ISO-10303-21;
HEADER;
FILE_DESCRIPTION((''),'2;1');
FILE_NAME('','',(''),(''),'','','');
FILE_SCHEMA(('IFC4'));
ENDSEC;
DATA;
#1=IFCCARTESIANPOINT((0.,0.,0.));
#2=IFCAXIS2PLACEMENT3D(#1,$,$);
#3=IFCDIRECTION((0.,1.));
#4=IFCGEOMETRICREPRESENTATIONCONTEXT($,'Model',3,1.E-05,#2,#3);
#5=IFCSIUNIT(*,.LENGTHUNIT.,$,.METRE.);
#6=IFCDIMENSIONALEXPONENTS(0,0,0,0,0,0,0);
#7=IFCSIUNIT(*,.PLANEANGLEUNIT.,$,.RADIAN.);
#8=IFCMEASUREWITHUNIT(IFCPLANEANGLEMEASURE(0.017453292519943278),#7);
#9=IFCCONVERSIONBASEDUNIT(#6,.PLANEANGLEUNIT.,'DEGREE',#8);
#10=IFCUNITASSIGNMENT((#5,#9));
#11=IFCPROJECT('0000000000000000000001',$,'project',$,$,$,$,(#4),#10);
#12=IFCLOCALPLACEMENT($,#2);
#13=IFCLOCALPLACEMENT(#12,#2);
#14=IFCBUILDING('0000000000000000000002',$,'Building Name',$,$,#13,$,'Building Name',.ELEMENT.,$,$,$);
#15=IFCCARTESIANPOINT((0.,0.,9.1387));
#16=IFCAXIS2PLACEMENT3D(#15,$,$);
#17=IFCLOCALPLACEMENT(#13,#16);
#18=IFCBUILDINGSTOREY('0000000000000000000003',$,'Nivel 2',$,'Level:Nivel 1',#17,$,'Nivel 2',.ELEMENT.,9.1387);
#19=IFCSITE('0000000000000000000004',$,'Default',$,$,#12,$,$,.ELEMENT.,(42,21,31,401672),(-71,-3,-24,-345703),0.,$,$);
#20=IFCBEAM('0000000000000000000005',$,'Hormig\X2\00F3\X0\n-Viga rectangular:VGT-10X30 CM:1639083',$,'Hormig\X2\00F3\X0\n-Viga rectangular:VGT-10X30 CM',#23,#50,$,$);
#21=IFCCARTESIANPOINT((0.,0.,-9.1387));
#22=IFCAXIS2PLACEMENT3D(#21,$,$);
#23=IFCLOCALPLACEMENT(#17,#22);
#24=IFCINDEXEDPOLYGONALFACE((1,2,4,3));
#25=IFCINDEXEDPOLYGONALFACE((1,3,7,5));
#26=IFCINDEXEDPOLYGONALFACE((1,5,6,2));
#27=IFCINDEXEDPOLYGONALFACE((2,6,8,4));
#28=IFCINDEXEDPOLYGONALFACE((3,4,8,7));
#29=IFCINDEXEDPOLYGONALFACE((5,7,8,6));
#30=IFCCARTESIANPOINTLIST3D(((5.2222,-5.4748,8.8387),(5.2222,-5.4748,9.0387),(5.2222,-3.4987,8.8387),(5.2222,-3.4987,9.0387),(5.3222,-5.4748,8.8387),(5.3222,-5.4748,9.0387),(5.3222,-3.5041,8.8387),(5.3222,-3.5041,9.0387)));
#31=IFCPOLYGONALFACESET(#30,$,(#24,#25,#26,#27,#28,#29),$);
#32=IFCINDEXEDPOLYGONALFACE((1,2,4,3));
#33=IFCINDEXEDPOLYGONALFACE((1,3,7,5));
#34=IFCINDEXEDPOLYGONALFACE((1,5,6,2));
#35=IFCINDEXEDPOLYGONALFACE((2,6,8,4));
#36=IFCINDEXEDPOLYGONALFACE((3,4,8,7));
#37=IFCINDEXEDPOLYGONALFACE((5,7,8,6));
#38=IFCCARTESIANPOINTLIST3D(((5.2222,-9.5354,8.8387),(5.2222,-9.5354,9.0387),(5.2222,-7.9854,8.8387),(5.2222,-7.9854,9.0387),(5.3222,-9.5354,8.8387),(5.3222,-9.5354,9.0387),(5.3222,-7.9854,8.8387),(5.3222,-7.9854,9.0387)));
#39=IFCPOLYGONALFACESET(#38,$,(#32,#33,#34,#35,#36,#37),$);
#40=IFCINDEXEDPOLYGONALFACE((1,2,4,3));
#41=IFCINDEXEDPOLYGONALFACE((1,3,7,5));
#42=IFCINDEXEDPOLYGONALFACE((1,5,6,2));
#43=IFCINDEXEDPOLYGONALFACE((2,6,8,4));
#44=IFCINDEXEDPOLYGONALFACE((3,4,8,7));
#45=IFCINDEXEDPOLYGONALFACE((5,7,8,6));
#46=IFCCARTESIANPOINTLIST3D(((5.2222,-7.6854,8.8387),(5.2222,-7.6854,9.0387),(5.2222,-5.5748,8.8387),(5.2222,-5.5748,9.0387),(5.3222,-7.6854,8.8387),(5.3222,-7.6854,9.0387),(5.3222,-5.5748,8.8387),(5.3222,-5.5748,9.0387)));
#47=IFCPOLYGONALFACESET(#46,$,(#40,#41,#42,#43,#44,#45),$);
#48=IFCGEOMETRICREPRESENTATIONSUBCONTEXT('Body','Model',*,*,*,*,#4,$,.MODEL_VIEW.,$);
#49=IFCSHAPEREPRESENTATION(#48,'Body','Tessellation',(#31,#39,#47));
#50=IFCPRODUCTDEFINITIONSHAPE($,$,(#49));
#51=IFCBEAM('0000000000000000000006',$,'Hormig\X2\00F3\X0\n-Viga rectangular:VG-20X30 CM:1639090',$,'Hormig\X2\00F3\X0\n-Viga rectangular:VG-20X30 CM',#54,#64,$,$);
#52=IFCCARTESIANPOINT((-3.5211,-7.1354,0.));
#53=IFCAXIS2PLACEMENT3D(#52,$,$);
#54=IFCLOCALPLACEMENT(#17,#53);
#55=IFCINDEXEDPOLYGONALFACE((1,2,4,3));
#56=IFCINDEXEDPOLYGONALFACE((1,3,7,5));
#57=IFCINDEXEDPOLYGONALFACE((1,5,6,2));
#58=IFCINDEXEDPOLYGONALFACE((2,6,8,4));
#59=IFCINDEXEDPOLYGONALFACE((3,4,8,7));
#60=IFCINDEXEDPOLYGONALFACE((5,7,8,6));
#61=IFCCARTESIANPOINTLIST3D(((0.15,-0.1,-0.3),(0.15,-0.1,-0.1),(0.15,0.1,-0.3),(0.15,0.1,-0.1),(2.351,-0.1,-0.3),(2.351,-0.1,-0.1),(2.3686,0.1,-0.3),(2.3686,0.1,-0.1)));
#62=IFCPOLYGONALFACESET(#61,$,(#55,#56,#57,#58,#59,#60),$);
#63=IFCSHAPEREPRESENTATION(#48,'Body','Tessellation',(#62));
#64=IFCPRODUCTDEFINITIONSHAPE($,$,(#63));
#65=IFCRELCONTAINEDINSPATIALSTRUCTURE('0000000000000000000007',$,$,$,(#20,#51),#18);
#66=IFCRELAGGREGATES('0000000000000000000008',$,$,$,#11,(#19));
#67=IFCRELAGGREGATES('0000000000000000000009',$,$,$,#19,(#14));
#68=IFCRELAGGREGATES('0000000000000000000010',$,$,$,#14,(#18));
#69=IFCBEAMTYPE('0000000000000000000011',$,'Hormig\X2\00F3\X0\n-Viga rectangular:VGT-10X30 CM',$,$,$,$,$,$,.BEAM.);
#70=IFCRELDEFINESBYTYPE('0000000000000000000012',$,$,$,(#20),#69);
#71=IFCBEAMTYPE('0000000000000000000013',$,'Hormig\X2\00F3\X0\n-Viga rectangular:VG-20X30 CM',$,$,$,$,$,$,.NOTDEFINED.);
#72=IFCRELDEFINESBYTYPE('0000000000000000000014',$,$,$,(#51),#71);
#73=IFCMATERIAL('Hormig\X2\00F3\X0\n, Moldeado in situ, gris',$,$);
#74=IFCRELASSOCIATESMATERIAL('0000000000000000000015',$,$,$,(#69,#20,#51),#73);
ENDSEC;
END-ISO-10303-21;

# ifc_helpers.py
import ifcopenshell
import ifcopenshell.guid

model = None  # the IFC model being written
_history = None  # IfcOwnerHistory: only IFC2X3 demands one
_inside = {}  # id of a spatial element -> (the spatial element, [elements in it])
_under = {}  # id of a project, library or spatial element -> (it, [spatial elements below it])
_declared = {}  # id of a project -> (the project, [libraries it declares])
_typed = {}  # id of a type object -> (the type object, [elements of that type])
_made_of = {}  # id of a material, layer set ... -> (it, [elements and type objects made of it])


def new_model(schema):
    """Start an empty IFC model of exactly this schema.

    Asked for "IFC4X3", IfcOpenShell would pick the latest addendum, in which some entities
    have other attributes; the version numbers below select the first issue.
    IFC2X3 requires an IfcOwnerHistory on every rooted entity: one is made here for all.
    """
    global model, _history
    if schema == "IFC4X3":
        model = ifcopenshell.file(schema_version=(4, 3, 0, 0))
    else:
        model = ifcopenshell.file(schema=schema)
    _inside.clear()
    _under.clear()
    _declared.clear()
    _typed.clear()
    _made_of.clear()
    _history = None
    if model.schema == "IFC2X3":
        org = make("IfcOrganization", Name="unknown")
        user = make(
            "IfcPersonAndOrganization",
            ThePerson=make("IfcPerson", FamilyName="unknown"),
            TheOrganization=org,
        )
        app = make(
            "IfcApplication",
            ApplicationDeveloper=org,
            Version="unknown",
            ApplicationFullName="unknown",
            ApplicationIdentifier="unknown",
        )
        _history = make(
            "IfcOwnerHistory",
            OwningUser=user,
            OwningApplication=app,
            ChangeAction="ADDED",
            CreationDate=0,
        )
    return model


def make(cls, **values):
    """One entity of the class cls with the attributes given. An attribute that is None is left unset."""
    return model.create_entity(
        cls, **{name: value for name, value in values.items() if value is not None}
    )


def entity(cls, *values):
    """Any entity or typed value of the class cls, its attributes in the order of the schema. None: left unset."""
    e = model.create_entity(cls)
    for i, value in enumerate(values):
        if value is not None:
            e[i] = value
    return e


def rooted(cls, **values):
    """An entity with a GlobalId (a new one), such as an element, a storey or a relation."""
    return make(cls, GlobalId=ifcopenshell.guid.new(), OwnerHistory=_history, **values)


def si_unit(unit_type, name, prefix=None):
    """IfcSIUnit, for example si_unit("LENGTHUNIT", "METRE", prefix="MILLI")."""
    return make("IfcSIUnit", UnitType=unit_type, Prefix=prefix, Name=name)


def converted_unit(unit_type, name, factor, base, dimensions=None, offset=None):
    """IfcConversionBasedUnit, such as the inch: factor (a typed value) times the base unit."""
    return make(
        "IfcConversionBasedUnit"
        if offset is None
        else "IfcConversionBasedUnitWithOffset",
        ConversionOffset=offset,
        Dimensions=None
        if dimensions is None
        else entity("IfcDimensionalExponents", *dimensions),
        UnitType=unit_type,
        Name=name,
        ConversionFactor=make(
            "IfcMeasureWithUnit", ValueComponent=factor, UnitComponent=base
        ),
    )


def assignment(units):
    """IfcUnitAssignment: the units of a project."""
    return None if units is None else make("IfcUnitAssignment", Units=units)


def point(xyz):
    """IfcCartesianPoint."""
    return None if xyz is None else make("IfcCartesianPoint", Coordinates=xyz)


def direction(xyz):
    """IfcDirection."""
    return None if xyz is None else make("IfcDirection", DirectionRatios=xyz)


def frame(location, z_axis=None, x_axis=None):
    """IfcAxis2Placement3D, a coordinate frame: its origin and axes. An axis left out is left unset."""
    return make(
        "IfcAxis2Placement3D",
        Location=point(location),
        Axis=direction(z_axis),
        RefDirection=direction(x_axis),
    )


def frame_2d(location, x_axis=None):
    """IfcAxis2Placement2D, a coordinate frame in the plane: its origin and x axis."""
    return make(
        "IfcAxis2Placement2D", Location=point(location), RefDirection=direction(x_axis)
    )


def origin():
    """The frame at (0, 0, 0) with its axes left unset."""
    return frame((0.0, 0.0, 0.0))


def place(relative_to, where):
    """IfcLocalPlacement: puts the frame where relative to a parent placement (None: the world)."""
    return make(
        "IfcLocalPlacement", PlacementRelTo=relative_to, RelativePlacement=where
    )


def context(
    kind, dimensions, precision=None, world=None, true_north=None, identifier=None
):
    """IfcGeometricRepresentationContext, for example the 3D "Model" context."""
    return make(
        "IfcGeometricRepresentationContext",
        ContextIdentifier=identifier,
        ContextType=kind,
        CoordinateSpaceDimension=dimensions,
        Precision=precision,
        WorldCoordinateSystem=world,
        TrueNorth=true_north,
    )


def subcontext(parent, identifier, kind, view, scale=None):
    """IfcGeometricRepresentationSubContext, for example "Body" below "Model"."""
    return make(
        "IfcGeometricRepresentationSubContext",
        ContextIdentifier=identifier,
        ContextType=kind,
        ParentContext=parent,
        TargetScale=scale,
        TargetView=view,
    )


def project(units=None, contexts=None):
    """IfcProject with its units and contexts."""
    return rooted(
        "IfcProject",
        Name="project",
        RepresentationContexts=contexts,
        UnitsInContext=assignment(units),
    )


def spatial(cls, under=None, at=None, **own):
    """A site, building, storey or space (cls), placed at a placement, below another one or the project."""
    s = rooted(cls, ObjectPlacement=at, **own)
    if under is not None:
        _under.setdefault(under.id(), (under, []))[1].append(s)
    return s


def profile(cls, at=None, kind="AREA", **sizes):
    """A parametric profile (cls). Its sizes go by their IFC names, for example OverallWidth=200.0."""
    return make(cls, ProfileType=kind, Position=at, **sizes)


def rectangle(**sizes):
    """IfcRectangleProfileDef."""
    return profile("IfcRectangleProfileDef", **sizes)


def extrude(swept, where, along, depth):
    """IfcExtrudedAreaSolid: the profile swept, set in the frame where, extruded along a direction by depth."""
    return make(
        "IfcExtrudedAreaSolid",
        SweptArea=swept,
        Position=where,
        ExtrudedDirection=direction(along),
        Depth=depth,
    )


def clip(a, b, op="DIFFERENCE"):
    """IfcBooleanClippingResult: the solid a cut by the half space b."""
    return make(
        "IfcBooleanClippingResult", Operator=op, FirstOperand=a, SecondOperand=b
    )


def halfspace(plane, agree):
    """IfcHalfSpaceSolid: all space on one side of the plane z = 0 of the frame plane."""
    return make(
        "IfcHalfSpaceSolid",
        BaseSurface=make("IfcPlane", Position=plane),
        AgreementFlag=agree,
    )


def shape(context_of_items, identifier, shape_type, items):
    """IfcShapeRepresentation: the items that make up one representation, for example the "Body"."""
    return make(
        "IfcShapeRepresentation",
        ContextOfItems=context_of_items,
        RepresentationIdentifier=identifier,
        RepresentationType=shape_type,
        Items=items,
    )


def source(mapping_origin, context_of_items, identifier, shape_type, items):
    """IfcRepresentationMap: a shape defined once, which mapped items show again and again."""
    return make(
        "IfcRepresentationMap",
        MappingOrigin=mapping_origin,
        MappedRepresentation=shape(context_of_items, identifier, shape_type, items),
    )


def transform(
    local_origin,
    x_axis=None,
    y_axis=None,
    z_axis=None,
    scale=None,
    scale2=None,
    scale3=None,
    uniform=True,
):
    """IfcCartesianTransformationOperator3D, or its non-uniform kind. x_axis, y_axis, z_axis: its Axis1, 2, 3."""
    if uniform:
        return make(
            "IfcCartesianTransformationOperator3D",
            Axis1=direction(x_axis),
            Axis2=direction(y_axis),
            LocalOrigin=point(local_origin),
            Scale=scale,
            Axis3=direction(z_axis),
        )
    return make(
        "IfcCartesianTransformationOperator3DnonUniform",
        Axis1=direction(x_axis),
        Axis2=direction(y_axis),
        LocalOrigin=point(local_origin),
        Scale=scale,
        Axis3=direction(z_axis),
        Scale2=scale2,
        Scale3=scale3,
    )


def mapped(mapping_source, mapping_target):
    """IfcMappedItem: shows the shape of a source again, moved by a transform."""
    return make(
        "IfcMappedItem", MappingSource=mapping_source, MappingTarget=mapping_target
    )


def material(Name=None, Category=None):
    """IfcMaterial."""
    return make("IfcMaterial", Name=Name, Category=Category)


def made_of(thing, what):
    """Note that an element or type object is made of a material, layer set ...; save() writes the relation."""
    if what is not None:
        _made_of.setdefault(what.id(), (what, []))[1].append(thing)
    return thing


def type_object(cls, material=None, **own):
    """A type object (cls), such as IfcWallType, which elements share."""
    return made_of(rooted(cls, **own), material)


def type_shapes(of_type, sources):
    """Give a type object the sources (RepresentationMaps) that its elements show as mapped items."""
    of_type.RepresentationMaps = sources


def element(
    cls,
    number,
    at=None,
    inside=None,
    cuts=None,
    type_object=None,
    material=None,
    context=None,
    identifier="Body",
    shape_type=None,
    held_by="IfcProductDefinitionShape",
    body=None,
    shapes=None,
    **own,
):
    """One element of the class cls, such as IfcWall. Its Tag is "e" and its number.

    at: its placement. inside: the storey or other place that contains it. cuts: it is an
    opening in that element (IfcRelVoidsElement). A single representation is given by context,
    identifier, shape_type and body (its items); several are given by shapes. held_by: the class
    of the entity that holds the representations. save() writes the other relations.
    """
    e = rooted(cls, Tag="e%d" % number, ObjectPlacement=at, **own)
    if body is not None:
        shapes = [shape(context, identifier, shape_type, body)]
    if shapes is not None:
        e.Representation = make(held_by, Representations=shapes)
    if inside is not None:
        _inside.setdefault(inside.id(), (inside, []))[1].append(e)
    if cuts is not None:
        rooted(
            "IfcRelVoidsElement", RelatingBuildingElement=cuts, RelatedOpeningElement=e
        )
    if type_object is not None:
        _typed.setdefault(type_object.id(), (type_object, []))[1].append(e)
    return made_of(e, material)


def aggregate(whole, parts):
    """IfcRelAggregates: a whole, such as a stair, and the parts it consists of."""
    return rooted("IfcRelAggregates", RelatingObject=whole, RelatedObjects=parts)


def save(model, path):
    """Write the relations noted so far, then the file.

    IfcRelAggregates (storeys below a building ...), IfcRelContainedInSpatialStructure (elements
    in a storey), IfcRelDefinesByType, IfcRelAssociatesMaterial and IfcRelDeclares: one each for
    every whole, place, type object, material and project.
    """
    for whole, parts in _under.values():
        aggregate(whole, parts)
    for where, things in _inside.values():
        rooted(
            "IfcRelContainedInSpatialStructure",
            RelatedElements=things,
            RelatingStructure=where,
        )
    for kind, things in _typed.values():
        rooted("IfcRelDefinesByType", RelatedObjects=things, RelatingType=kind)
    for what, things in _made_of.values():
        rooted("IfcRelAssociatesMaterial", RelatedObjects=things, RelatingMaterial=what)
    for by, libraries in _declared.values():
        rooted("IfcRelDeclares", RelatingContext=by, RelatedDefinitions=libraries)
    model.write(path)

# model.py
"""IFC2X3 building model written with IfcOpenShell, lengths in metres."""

from ifc_helpers import new_model, entity, si_unit, converted_unit, direction, frame, frame_2d, origin, place, context, subcontext, project, spatial, rectangle, extrude, clip, halfspace, source, transform, mapped, material, type_object, type_shapes, element, save


model = new_model("IFC2X3")

# Units and contexts
model_context = context("Model", 3, precision=1e-05, world=origin(), true_north=direction((0.0, 1.0)))
body_context = subcontext(model_context, "Body", "Model", "MODEL_VIEW")
ifc_project = project(units=[si_unit("LENGTHUNIT", "METRE"), converted_unit("PLANEANGLEUNIT", "DEGREE", entity("IfcPlaneAngleMeasure", 0.017453292519943278), si_unit("PLANEANGLEUNIT", "RADIAN"), dimensions=[0, 0, 0, 0, 0, 0, 0])], contexts=[model_context])

# Site, building, storey
site_placement = place(None, origin())
site = spatial("IfcSite", under=ifc_project, at=site_placement, Name="Default", CompositionType="ELEMENT", RefLatitude=(42, 21, 31, 401672), RefLongitude=(-71, -3, -24, -345703), RefElevation=0.0)
building_placement = place(site_placement, origin())
building = spatial("IfcBuilding", under=site, at=building_placement, Name="Building Name", LongName="Building Name", CompositionType="ELEMENT")
storey_placement = place(building_placement, frame((0.0, 0.0, 9.1387)))
storey = spatial("IfcBuildingStorey", under=building, at=storey_placement, Name="Nivel 2", ObjectType="Level:Nivel 1", LongName="Nivel 2", CompositionType="ELEMENT", Elevation=9.1387)

# Beams
ifc_material = material(Name="Hormigón, Moldeado in situ, gris")
beam_type_1 = type_object("IfcBeamType", Name="Hormigón-Viga rectangular:VGT-10X30 CM", PredefinedType="BEAM", material=ifc_material)
shared_shape_1 = source(origin(), body_context, "Body", "SweptSolid", [
    clip(extrude(rectangle(XDim=0.2, YDim=0.1, at=frame_2d((0.0, 0.0), x_axis=(0.0, 1.0))), frame((5.2722, -3.4987, 8.9387), z_axis=(0.0, -1.0, 0.0), x_axis=(-1.0, 0.0, 0.0)), (0.0, 0.0, 1.0), 1.9761), halfspace(frame((7.5858, -3.6267, 9.1387), z_axis=(0.054083, 0.998536, 0.0), x_axis=(-0.998536, 0.054083, 0.0)), False)),
    extrude(rectangle(XDim=0.2, YDim=0.1, at=frame_2d((0.0, 0.0), x_axis=(0.0, 1.0))), frame((5.2722, -7.9854, 8.9387), z_axis=(0.0, -1.0, 0.0), x_axis=(-1.0, 0.0, 0.0)), (0.0, 0.0, 1.0), 1.55),
    extrude(rectangle(XDim=0.2, YDim=0.1, at=frame_2d((0.0, 0.0), x_axis=(0.0, 1.0))), frame((5.2722, -5.5748, 8.9387), z_axis=(0.0, -1.0, 0.0), x_axis=(-1.0, 0.0, 0.0)), (0.0, 0.0, 1.0), 2.1107),
])
type_shapes(beam_type_1, [shared_shape_1])
beam_1_placement = place(storey_placement, frame((0.0, 0.0, -9.1387)))
element("IfcBeam", 1, at=beam_1_placement, inside=storey, type_object=beam_type_1, material=ifc_material, Name="Hormigón-Viga rectangular:VGT-10X30 CM:1639083", ObjectType="Hormigón-Viga rectangular:VGT-10X30 CM", context=body_context, shape_type="MappedRepresentation", body=[
    mapped(shared_shape_1, transform((0.0, 0.0, 0.0), scale=1.0)),
])
beam_type_2 = type_object("IfcBeamType", Name="Hormigón-Viga rectangular:VG-20X30 CM", PredefinedType="NOTDEFINED")
beam_2_placement = place(storey_placement, frame((-3.5211, -7.1354, 0.0)))
element("IfcBeam", 2, at=beam_2_placement, inside=storey, type_object=beam_type_2, material=ifc_material, Name="Hormigón-Viga rectangular:VG-20X30 CM:1639090", ObjectType="Hormigón-Viga rectangular:VG-20X30 CM", context=body_context, shape_type="SweptSolid", body=[
    clip(extrude(rectangle(XDim=0.2, YDim=0.2, at=frame_2d((0.0, 0.0), x_axis=(1.0, 0.0))), frame((0.15, 0.0, -0.2), z_axis=(1.0, 0.0, 0.0), x_axis=(0.0, 0.0, -1.0)), (0.0, 0.0, 1.0), 2.2186), halfspace(frame((2.3138, -0.5244, 0.0), z_axis=(0.996168, -0.087456, 0.0), x_axis=(0.087456, 0.996168, 0.0)), False)),
])

save(model, "model.ifc")
